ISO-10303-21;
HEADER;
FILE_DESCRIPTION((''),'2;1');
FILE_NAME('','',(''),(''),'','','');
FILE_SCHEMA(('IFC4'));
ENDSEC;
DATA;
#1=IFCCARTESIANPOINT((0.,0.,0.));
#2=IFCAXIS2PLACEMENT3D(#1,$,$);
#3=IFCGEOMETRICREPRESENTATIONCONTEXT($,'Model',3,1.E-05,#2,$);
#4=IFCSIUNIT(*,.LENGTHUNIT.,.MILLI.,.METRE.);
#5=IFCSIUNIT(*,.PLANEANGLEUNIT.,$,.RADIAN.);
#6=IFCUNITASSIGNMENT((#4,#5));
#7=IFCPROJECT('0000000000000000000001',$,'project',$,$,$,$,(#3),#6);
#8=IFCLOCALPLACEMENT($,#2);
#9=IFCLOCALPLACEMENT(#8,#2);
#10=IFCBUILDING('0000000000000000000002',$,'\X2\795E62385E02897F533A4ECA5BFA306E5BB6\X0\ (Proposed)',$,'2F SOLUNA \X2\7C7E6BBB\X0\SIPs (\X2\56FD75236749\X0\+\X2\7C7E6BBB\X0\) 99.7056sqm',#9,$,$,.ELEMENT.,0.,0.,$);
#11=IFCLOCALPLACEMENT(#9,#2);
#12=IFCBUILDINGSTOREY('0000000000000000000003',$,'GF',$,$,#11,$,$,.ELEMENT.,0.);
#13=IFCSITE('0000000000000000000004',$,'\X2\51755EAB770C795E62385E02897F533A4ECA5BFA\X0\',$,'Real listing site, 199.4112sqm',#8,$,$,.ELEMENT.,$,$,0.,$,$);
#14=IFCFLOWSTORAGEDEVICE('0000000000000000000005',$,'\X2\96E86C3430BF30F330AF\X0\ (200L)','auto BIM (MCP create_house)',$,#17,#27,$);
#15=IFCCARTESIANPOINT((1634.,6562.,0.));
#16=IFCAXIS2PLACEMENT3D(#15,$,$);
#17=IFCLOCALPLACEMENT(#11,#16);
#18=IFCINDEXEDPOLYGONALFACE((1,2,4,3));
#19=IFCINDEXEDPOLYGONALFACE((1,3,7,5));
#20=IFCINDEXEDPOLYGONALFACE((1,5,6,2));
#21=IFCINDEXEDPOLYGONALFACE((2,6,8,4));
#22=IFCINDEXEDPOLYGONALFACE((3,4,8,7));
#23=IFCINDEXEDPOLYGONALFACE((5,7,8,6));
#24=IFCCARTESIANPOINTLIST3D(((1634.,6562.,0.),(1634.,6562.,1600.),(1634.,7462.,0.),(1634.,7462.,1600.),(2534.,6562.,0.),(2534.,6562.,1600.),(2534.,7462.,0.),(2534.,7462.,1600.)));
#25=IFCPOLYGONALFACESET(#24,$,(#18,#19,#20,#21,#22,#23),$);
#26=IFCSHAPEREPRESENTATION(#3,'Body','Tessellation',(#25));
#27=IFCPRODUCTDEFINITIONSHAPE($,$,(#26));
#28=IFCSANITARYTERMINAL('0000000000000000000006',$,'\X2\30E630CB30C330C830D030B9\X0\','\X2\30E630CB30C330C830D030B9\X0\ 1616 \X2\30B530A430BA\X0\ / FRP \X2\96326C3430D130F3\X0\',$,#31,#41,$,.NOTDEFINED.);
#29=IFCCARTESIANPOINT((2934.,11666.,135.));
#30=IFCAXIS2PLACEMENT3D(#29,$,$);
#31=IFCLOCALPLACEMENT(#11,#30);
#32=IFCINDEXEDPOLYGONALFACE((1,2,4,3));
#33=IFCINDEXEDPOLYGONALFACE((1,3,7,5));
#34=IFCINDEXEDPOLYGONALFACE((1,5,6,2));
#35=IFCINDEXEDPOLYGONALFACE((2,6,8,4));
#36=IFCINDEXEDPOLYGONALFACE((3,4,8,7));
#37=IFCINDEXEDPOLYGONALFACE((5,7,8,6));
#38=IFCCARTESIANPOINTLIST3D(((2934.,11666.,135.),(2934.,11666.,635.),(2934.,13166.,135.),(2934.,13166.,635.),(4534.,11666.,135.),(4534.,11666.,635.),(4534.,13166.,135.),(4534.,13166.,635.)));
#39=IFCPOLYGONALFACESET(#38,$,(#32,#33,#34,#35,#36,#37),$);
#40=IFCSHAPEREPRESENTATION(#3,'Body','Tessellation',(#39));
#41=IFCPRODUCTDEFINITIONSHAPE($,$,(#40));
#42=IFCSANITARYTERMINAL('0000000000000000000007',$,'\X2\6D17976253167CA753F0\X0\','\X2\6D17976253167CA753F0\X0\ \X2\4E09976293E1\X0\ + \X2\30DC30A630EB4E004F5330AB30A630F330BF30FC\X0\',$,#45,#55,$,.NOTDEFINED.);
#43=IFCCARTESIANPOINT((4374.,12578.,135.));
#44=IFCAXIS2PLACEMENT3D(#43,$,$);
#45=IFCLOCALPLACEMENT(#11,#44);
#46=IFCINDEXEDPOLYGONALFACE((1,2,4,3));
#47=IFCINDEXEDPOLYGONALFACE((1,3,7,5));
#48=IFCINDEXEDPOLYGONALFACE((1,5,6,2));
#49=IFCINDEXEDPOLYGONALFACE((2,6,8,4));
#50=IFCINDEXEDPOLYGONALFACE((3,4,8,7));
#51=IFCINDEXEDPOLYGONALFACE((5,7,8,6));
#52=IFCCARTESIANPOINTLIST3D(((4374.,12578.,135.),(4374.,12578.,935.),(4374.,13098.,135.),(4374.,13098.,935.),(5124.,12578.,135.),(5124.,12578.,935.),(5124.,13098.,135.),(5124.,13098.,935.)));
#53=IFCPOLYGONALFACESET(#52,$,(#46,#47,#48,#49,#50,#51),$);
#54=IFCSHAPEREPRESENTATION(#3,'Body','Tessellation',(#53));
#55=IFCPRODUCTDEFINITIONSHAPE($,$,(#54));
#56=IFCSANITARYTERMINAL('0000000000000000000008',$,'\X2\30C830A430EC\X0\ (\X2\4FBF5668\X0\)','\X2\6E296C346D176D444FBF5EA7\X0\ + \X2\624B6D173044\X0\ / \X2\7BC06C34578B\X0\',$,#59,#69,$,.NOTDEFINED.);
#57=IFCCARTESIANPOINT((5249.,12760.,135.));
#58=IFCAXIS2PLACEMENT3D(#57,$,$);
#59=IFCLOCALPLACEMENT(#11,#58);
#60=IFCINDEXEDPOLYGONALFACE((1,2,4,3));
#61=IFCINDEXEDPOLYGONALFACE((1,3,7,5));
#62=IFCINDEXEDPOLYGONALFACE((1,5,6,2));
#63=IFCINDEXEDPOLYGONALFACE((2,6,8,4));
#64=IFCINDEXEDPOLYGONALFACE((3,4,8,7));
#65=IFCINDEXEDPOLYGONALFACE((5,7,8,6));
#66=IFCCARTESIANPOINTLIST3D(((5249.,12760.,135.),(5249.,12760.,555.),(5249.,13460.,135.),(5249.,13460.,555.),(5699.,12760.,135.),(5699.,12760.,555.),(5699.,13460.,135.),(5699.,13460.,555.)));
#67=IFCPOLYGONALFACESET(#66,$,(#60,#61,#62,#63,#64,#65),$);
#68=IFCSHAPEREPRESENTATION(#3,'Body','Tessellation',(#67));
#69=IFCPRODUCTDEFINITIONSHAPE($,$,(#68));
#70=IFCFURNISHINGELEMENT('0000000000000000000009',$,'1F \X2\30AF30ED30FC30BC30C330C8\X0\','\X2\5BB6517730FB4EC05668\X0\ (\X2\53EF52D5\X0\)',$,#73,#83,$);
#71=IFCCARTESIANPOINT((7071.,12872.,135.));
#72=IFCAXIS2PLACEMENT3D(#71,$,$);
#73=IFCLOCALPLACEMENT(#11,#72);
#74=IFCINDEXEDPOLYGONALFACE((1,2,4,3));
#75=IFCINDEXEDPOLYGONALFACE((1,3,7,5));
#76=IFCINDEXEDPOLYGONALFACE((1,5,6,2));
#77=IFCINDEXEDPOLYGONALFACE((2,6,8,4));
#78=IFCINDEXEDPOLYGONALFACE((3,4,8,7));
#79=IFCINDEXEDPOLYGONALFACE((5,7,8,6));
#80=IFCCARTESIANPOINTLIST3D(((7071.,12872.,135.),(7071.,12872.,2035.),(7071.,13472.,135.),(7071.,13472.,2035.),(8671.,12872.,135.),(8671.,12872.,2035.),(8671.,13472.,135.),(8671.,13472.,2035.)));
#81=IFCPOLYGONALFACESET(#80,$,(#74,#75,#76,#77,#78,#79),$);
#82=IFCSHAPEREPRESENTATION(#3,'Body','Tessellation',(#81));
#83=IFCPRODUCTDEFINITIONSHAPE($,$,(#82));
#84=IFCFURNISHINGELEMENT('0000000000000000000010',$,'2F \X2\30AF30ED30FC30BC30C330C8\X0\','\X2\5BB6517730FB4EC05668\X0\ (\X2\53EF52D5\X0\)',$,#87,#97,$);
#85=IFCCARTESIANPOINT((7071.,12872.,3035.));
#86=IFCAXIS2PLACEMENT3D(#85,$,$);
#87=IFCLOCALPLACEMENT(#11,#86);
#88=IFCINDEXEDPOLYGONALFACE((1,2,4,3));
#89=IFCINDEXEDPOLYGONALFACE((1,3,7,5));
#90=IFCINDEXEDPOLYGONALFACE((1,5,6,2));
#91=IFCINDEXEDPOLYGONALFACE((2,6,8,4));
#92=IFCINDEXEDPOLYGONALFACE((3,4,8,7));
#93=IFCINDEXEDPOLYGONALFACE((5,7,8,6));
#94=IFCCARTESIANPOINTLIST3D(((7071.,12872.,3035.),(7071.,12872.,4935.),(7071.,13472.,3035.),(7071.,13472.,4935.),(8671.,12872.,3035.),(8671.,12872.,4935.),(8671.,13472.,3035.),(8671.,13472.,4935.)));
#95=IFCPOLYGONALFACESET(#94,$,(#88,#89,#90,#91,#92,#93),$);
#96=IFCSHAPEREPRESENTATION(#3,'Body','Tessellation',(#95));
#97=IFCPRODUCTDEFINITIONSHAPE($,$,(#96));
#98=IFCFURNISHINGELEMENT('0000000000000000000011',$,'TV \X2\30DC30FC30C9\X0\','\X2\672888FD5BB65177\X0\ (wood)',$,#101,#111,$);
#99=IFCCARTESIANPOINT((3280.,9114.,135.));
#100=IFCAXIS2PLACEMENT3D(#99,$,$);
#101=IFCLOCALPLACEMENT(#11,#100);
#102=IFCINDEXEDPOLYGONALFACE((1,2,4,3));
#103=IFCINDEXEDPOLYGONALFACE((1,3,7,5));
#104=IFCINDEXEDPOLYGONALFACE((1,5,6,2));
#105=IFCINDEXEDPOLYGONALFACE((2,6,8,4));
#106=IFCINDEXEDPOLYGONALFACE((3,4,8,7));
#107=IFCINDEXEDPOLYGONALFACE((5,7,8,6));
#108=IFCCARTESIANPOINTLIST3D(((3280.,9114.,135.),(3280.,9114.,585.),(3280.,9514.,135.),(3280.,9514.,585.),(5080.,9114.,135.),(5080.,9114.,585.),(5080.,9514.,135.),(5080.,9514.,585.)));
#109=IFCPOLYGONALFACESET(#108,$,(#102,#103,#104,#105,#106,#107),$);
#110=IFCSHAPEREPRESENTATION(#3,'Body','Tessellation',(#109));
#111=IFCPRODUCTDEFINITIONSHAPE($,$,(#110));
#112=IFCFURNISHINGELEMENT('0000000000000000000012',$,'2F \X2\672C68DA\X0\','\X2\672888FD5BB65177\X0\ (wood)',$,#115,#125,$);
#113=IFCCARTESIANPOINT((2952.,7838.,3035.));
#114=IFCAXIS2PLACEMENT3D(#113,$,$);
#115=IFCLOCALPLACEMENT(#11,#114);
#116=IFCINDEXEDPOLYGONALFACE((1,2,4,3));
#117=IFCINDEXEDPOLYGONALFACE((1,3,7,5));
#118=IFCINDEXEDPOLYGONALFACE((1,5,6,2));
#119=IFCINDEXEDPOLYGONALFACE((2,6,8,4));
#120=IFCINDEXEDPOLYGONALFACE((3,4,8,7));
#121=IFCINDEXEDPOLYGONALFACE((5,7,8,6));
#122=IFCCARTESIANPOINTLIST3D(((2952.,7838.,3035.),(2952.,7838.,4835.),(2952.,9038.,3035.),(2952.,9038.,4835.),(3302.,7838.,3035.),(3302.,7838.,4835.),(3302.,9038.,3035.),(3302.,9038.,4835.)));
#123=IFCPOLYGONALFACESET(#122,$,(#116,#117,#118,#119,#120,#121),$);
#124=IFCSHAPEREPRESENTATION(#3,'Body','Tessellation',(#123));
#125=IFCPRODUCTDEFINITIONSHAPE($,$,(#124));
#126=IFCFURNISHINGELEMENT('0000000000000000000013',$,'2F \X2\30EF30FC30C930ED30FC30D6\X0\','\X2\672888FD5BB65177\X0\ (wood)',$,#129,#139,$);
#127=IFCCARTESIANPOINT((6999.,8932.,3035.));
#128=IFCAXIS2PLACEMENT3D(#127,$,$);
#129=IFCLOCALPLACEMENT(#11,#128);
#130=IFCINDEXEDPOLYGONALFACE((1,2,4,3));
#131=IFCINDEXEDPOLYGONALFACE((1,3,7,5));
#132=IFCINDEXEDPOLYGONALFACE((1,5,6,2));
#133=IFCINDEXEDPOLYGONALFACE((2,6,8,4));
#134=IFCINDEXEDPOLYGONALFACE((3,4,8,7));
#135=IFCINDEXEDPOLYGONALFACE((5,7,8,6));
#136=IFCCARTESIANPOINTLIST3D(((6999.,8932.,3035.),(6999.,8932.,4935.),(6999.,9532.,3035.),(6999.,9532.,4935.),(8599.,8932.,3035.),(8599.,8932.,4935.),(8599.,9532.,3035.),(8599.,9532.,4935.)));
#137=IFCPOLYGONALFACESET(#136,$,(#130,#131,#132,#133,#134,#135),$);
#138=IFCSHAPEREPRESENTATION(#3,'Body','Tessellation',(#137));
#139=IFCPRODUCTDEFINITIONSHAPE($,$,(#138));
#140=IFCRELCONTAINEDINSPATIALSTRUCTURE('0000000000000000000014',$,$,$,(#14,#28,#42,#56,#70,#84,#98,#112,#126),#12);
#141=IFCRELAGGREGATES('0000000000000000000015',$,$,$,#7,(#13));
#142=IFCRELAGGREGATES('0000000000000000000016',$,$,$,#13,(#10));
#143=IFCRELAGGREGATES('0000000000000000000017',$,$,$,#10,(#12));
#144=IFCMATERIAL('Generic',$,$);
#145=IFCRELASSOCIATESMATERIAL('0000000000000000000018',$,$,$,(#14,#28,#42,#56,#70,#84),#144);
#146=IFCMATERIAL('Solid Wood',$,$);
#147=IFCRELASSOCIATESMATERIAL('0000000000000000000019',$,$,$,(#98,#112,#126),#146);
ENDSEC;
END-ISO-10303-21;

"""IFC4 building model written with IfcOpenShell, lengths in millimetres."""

from ifc_helpers import new_model, si_unit, frame, frame_2d, origin, place, context, project, spatial, rectangle, extrude, material, element, save


model = new_model("IFC4")

# Units and contexts
model_context = context("Model", 3, precision=1e-05, world=origin())
ifc_project = project(units=[si_unit("LENGTHUNIT", "METRE", prefix="MILLI"), si_unit("PLANEANGLEUNIT", "RADIAN")], contexts=[model_context])

# Site, building, storey
site_placement = place(None, origin())
site = spatial("IfcSite", under=ifc_project, at=site_placement, Name="兵庫県神戸市西区今寺", ObjectType="Real listing site, 199.4112sqm", CompositionType="ELEMENT", RefElevation=0.0)
building_placement = place(site_placement, origin())
building = spatial("IfcBuilding", under=site, at=building_placement, Name="神戸市西区今寺の家 (Proposed)", ObjectType="2F SOLUNA 籾殻SIPs (国産杉+籾殻) 99.7056sqm", CompositionType="ELEMENT", ElevationOfRefHeight=0.0, ElevationOfTerrain=0.0)
storey_placement = place(building_placement, origin())
storey = spatial("IfcBuildingStorey", under=building, at=storey_placement, Name="GF", CompositionType="ELEMENT", Elevation=0.0)

# Shared definitions
ifc_material_1 = material(Name="Solid Wood")

# Flow storage device
ifc_material_2 = material(Name="Generic")
flow_storage_device_placement = place(storey_placement, frame((1634.0, 6562.0, 0.0)))
element("IfcFlowStorageDevice", 1, at=flow_storage_device_placement, inside=storey, material=ifc_material_2, Name="雨水タンク (200L)", Description="auto BIM (MCP create_house)", context=model_context, shape_type="SweptSolid", body=[
    extrude(rectangle(XDim=900.0, YDim=900.0, at=frame_2d((450.0, 450.0))), frame((1634.0, 6562.0, 0.0)), (0.0, 0.0, 1.0), 1600.0),
])

# Sanitary terminals
sanitary_terminal_1_placement = place(storey_placement, frame((2934.0, 11666.0, 135.0)))
element("IfcSanitaryTerminal", 2, at=sanitary_terminal_1_placement, inside=storey, material=ifc_material_2, Name="ユニットバス", Description="ユニットバス 1616 サイズ / FRP 防水パン", PredefinedType="NOTDEFINED", context=model_context, shape_type="SweptSolid", body=[
    extrude(rectangle(XDim=1600.0, YDim=1500.0, at=frame_2d((800.0, 750.0))), frame((2934.0, 11666.0, 135.0)), (0.0, 0.0, 1.0), 500.0),
])
sanitary_terminal_2_placement = place(storey_placement, frame((4374.0, 12578.0, 135.0)))
element("IfcSanitaryTerminal", 3, at=sanitary_terminal_2_placement, inside=storey, material=ifc_material_2, Name="洗面化粧台", Description="洗面化粧台 三面鏡 + ボウル一体カウンター", PredefinedType="NOTDEFINED", context=model_context, shape_type="SweptSolid", body=[
    extrude(rectangle(XDim=750.0, YDim=520.0, at=frame_2d((375.0, 260.0))), frame((4374.0, 12578.0, 135.0)), (0.0, 0.0, 1.0), 800.0),
])
sanitary_terminal_3_placement = place(storey_placement, frame((5249.0, 12760.0, 135.0)))
element("IfcSanitaryTerminal", 4, at=sanitary_terminal_3_placement, inside=storey, material=ifc_material_2, Name="トイレ (便器)", Description="温水洗浄便座 + 手洗い / 節水型", PredefinedType="NOTDEFINED", context=model_context, shape_type="SweptSolid", body=[
    extrude(rectangle(XDim=450.0, YDim=700.0, at=frame_2d((225.0, 350.0))), frame((5249.0, 12760.0, 135.0)), (0.0, 0.0, 1.0), 420.0),
])

# Furnishing elements
furnishing_1_placement = place(storey_placement, frame((7071.0, 12872.0, 135.0)))
element("IfcFurnishingElement", 5, at=furnishing_1_placement, inside=storey, material=ifc_material_2, Name="1F クローゼット", Description="家具・什器 (可動)", context=model_context, shape_type="SweptSolid", body=[
    extrude(rectangle(XDim=1600.0, YDim=600.0, at=frame_2d((800.0, 300.0))), frame((7071.0, 12872.0, 135.0)), (0.0, 0.0, 1.0), 1900.0),
])
furnishing_2_placement = place(storey_placement, frame((7071.0, 12872.0, 3035.0)))
element("IfcFurnishingElement", 6, at=furnishing_2_placement, inside=storey, material=ifc_material_2, Name="2F クローゼット", Description="家具・什器 (可動)", context=model_context, shape_type="SweptSolid", body=[
    extrude(rectangle(XDim=1600.0, YDim=600.0, at=frame_2d((800.0, 300.0))), frame((7071.0, 12872.0, 3035.0)), (0.0, 0.0, 1.0), 1900.0),
])
furnishing_3_placement = place(storey_placement, frame((3280.0, 9114.0, 135.0)))
element("IfcFurnishingElement", 7, at=furnishing_3_placement, inside=storey, material=ifc_material_1, Name="TV ボード", Description="木製家具 (wood)", context=model_context, shape_type="SweptSolid", body=[
    extrude(rectangle(XDim=1800.0, YDim=400.0, at=frame_2d((900.0, 200.0))), frame((3280.0, 9114.0, 135.0)), (0.0, 0.0, 1.0), 450.0),
])
furnishing_4_placement = place(storey_placement, frame((2952.0, 7838.0, 3035.0)))
element("IfcFurnishingElement", 8, at=furnishing_4_placement, inside=storey, material=ifc_material_1, Name="2F 本棚", Description="木製家具 (wood)", context=model_context, shape_type="SweptSolid", body=[
    extrude(rectangle(XDim=350.0, YDim=1200.0, at=frame_2d((175.0, 600.0))), frame((2952.0, 7838.0, 3035.0)), (0.0, 0.0, 1.0), 1800.0),
])
furnishing_5_placement = place(storey_placement, frame((6999.0, 8932.0, 3035.0)))
element("IfcFurnishingElement", 9, at=furnishing_5_placement, inside=storey, material=ifc_material_1, Name="2F ワードローブ", Description="木製家具 (wood)", context=model_context, shape_type="SweptSolid", body=[
    extrude(rectangle(XDim=1600.0, YDim=600.0, at=frame_2d((800.0, 300.0))), frame((6999.0, 8932.0, 3035.0)), (0.0, 0.0, 1.0), 1900.0),
])

save(model, "model.ifc")
